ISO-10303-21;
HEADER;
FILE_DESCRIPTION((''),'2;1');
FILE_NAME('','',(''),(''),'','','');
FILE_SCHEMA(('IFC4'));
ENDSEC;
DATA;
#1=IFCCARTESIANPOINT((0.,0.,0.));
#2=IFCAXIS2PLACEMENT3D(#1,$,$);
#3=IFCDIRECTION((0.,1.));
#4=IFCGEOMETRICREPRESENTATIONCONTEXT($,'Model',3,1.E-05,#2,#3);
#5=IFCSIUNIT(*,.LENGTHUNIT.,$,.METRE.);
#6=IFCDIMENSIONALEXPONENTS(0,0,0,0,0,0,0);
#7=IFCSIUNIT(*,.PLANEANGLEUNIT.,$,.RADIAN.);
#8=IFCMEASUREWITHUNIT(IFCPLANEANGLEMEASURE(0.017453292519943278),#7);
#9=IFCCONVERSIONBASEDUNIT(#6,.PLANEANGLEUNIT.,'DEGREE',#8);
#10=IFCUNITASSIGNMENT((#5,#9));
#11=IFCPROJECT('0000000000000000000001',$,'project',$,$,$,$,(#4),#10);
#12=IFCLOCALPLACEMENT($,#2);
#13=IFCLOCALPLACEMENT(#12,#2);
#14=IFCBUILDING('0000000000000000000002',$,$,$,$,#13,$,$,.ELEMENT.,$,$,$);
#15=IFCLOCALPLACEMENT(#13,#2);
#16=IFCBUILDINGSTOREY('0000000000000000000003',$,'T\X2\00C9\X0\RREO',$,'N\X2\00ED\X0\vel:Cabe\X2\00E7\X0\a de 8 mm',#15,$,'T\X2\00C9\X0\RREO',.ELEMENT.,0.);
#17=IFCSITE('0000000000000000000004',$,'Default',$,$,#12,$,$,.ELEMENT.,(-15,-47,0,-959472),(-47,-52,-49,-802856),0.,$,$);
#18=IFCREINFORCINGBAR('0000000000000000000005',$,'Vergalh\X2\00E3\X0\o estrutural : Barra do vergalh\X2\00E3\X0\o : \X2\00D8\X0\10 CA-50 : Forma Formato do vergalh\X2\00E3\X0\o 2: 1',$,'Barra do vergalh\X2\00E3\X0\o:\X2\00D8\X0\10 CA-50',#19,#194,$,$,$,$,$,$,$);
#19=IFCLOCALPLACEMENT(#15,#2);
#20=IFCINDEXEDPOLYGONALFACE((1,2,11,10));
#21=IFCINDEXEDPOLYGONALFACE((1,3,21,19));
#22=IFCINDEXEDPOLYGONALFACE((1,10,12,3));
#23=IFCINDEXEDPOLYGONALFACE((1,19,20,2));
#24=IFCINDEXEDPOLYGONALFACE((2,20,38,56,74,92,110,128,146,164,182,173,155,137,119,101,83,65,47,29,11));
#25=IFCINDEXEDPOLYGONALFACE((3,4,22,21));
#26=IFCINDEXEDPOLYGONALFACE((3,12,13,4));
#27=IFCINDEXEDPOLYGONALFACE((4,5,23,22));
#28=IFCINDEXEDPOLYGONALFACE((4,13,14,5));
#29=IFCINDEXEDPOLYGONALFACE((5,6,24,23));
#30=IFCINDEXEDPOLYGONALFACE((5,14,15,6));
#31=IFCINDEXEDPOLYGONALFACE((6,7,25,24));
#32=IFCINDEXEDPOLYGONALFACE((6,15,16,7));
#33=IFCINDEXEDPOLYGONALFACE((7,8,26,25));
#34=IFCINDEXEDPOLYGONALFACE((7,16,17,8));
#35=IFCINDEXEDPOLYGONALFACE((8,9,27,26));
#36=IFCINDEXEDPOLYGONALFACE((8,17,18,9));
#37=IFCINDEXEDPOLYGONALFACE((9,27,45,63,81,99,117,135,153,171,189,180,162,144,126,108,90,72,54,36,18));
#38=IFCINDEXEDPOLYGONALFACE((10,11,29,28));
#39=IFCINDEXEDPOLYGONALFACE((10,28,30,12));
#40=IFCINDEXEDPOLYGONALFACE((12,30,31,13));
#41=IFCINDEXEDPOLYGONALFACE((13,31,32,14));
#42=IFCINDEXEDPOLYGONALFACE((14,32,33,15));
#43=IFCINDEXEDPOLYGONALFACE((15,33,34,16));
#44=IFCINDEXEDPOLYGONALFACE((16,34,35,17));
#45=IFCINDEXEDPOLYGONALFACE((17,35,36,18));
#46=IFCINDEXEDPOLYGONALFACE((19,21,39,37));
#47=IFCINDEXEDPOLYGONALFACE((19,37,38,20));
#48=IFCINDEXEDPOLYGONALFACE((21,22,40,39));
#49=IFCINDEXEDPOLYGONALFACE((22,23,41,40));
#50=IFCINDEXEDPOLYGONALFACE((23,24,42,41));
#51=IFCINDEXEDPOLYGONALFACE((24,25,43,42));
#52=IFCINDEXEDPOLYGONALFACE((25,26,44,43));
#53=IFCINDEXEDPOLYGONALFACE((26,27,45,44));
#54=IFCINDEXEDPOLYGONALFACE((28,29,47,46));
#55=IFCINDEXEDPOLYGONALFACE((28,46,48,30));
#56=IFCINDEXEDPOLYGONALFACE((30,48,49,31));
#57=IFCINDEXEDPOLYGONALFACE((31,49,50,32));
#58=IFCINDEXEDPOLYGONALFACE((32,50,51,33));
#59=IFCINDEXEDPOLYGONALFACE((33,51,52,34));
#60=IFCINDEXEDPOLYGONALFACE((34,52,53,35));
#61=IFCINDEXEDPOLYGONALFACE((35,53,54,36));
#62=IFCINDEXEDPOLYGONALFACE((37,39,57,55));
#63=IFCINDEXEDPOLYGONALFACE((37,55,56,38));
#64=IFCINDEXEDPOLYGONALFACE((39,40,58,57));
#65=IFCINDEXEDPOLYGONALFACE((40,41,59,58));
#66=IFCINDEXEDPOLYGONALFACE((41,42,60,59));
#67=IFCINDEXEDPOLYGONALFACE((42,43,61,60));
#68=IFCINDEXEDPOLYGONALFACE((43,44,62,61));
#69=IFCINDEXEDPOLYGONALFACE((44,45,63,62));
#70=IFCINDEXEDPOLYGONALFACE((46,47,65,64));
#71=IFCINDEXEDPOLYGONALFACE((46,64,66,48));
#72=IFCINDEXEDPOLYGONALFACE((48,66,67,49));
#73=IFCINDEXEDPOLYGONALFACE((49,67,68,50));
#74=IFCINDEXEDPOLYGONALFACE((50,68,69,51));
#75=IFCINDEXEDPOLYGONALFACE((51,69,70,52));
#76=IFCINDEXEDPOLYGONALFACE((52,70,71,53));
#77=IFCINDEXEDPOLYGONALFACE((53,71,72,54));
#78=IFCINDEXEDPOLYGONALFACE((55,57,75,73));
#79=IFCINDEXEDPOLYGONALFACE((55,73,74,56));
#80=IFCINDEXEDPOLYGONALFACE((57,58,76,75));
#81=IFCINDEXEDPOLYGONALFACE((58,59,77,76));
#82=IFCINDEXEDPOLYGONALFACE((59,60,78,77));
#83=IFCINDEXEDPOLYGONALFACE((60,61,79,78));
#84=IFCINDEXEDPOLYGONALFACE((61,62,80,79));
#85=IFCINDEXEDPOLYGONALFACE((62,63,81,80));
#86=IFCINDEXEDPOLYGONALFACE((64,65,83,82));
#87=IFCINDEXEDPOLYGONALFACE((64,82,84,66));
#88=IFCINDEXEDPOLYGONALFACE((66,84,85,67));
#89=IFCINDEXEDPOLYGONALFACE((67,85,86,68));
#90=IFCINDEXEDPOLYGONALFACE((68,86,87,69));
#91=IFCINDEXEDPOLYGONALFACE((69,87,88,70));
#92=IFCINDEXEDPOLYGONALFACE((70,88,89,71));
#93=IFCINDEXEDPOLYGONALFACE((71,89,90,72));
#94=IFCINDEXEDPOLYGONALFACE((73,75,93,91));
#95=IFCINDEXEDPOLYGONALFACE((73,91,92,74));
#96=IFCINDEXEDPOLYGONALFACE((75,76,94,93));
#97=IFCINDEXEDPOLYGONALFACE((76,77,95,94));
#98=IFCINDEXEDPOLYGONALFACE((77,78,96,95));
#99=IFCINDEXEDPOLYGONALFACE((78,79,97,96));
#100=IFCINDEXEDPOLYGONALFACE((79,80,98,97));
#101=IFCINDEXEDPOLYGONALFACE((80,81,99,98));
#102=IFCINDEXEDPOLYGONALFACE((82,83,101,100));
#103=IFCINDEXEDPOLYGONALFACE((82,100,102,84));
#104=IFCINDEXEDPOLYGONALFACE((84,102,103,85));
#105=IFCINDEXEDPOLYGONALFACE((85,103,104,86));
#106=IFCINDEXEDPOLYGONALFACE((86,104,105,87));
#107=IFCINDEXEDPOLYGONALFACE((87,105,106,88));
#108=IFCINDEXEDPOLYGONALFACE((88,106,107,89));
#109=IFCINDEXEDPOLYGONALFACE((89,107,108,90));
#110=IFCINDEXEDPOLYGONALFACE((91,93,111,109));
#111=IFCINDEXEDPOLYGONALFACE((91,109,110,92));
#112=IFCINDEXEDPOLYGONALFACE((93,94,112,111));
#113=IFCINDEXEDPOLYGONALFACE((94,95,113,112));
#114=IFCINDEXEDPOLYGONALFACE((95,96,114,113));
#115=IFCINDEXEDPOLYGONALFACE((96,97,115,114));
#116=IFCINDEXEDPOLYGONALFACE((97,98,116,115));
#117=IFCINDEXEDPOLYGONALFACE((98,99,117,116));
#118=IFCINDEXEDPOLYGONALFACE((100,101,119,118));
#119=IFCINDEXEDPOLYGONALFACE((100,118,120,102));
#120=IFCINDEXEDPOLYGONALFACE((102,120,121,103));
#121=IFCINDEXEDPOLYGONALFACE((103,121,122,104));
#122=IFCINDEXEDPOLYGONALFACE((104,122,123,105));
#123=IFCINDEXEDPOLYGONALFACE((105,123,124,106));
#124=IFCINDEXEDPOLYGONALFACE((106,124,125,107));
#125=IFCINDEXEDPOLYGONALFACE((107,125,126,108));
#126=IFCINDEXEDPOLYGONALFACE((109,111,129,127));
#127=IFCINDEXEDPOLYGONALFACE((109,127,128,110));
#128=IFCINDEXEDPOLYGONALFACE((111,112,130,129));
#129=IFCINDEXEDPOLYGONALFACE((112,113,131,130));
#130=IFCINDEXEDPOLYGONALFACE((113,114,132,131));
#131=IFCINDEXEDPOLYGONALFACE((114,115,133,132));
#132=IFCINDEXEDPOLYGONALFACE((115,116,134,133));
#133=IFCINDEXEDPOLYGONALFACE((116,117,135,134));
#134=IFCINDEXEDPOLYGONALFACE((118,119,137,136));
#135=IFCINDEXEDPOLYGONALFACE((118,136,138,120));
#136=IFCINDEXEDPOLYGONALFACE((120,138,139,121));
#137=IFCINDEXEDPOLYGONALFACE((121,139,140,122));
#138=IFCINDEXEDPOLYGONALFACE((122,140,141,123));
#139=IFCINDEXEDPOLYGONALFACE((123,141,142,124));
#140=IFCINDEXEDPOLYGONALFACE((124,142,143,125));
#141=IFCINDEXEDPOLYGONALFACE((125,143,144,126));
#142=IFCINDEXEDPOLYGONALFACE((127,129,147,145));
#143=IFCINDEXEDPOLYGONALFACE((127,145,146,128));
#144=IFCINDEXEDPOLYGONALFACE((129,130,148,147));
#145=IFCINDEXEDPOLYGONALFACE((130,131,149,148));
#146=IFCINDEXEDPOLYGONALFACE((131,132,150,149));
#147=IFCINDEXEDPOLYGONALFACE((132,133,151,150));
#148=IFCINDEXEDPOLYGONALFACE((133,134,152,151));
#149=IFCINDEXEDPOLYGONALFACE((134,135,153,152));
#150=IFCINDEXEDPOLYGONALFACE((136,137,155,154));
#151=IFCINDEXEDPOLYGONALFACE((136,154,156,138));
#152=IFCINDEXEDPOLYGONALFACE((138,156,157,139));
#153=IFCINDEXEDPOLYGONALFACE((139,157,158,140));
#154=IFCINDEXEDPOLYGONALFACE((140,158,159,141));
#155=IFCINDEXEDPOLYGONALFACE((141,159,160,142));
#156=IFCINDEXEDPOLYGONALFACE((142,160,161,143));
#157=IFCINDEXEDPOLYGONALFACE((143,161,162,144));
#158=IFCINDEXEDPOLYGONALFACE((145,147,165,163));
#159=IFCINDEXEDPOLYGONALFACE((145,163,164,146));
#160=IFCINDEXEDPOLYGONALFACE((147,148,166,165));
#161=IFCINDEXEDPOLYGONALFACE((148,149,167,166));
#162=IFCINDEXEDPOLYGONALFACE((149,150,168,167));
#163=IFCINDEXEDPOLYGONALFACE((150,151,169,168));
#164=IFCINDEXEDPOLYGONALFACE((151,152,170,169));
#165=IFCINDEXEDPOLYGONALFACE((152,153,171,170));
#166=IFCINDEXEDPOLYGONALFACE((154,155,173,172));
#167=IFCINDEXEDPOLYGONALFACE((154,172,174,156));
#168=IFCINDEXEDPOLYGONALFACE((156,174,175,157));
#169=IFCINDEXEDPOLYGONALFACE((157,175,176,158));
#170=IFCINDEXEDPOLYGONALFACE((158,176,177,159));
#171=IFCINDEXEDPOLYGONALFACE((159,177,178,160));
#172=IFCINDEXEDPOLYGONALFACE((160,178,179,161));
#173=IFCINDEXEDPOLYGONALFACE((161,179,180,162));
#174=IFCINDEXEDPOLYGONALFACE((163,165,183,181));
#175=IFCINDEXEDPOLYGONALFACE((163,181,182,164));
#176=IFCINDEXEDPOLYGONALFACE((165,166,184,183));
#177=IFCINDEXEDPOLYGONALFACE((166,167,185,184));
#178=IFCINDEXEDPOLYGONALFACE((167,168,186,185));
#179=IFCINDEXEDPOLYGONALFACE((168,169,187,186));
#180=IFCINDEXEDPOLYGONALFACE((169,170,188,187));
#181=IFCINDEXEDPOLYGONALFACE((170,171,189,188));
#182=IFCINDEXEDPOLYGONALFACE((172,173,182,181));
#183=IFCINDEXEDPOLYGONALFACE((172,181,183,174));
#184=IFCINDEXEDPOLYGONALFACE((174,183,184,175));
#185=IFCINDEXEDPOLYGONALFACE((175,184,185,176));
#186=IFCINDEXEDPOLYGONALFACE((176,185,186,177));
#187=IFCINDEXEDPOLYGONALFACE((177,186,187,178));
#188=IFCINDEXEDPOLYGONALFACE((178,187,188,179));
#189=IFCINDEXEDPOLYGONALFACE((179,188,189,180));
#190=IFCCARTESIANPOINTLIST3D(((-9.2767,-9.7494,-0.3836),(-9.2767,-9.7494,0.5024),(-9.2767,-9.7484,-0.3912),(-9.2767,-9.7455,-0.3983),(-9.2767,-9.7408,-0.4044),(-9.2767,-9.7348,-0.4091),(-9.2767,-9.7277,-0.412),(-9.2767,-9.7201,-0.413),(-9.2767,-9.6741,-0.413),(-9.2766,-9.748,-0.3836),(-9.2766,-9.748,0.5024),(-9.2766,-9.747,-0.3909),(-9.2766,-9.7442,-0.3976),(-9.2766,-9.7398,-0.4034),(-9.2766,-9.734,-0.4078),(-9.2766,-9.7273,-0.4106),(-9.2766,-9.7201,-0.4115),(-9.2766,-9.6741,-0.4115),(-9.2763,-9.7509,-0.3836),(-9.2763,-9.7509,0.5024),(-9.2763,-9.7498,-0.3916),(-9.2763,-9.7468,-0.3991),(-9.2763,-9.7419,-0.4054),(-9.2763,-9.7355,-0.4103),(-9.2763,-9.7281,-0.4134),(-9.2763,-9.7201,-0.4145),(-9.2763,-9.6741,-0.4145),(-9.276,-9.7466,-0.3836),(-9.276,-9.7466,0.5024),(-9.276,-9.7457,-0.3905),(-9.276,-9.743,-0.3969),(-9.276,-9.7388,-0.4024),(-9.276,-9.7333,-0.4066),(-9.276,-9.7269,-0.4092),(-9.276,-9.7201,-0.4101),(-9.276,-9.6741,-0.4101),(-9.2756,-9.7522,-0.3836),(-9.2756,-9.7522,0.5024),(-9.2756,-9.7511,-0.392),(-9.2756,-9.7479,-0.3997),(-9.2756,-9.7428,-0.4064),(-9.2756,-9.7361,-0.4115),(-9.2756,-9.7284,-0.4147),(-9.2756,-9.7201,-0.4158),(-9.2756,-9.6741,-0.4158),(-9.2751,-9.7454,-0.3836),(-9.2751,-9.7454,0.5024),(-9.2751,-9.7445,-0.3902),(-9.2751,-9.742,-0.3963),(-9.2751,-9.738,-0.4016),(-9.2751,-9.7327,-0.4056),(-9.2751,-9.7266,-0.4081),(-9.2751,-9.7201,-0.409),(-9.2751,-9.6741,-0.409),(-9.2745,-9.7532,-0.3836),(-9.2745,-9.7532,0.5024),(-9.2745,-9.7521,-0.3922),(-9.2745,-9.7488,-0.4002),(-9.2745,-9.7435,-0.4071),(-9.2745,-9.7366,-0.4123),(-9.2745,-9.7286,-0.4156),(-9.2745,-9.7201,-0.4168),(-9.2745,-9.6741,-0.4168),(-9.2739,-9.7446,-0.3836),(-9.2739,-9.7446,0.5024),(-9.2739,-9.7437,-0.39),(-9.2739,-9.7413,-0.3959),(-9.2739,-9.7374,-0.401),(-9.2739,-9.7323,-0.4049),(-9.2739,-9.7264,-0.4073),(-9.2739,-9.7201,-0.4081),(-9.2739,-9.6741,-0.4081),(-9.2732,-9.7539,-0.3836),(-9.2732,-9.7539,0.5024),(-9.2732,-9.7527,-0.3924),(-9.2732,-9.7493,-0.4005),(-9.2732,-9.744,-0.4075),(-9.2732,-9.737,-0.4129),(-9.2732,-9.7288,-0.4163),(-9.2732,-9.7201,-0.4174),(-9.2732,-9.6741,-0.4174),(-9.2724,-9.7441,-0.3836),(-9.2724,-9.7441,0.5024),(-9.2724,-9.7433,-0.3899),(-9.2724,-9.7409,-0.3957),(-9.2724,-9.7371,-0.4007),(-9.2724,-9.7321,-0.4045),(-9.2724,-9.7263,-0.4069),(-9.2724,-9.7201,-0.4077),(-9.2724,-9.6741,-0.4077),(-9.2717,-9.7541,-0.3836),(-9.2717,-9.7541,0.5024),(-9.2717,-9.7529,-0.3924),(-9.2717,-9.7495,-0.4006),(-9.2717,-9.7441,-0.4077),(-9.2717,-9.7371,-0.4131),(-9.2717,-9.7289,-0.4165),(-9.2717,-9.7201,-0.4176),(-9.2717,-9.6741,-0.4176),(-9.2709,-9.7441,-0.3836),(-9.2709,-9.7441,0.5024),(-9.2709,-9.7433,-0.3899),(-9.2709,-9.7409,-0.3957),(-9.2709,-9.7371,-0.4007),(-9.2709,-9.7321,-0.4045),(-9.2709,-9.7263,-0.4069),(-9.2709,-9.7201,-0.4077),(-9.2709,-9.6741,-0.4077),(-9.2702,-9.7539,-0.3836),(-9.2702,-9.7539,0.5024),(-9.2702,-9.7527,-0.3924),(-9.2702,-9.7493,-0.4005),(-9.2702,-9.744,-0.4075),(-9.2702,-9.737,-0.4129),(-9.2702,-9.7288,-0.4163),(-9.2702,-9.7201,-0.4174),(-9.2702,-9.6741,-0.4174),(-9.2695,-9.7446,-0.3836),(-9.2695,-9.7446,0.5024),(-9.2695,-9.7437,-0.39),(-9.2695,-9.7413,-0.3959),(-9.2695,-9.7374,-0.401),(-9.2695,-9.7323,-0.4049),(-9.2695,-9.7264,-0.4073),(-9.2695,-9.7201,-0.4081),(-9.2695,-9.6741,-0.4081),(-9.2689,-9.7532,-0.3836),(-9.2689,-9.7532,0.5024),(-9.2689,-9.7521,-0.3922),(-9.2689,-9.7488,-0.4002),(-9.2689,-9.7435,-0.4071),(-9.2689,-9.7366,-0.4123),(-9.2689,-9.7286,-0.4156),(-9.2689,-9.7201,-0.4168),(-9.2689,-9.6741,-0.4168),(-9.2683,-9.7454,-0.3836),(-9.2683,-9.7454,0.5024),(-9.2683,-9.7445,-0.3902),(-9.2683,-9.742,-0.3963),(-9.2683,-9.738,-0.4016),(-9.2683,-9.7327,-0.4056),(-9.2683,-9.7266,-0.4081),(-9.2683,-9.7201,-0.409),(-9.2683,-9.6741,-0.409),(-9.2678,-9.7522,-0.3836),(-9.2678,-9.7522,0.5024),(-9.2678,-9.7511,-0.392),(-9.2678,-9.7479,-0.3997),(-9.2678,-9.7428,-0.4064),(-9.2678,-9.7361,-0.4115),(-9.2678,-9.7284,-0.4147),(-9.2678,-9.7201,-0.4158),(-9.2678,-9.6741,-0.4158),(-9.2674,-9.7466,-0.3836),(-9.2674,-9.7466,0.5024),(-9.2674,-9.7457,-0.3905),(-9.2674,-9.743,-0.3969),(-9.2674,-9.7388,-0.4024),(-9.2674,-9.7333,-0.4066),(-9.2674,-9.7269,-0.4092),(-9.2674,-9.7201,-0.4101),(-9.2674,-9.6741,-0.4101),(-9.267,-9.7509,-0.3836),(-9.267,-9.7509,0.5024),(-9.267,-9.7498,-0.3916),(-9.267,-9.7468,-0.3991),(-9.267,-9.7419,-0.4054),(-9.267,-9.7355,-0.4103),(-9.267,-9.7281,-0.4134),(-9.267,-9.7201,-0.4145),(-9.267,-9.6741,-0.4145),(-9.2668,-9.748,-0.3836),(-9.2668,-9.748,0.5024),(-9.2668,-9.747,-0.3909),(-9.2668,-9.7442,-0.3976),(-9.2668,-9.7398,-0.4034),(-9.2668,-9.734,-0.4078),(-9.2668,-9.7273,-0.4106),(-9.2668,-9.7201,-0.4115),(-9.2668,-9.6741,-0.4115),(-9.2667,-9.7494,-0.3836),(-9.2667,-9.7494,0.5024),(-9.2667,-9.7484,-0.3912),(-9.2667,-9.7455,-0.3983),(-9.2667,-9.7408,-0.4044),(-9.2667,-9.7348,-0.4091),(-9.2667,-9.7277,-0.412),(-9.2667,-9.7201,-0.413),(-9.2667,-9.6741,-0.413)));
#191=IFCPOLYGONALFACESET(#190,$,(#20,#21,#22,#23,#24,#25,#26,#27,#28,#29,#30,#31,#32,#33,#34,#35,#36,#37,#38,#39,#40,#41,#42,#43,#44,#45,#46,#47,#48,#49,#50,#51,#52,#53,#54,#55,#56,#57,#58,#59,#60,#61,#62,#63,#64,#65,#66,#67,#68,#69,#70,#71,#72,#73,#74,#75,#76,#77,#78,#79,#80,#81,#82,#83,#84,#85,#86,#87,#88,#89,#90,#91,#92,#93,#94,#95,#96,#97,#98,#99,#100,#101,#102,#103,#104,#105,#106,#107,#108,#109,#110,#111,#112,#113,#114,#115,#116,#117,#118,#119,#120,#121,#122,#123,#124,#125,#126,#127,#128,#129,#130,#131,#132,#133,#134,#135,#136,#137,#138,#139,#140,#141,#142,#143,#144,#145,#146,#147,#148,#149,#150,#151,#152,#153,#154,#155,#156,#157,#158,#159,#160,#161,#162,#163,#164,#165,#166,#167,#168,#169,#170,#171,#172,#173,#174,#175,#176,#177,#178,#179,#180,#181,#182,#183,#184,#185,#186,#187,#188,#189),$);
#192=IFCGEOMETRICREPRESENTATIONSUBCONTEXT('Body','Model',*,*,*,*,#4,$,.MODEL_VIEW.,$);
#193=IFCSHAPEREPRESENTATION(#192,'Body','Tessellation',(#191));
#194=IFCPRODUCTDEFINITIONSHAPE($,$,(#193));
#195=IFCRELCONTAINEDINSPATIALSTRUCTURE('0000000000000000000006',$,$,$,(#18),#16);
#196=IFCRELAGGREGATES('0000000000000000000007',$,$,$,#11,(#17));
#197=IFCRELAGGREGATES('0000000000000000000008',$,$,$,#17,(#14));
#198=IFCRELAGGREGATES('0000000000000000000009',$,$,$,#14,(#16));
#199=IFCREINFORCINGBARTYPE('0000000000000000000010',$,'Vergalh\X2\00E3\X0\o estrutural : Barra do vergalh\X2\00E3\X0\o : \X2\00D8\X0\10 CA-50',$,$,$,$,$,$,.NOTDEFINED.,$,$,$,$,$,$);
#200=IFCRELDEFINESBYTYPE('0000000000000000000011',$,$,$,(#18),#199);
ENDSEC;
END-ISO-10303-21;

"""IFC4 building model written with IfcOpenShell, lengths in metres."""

from ifc_helpers import new_model, entity, si_unit, converted_unit, direction, origin, place, context, subcontext, project, spatial, type_object, element, save


model = new_model("IFC4")

# Units and contexts
model_context = context("Model", 3, precision=1e-05, world=origin(), true_north=direction((0.0, 1.0)))
body_context = subcontext(model_context, "Body", "Model", "MODEL_VIEW")
ifc_project = project(units=[si_unit("LENGTHUNIT", "METRE"), converted_unit("PLANEANGLEUNIT", "DEGREE", entity("IfcPlaneAngleMeasure", 0.017453292519943278), si_unit("PLANEANGLEUNIT", "RADIAN"), dimensions=[0, 0, 0, 0, 0, 0, 0])], contexts=[model_context])

# Site, building, storey
site_placement = place(None, origin())
site = spatial("IfcSite", under=ifc_project, at=site_placement, Name="Default", CompositionType="ELEMENT", RefLatitude=(-15, -47, 0, -959472), RefLongitude=(-47, -52, -49, -802856), RefElevation=0.0)
building_placement = place(site_placement, origin())
building = spatial("IfcBuilding", under=site, at=building_placement, CompositionType="ELEMENT")
storey_placement = place(building_placement, origin())
storey = spatial("IfcBuildingStorey", under=building, at=storey_placement, Name="TÉRREO", ObjectType="Nível:Cabeça de 8 mm", LongName="TÉRREO", CompositionType="ELEMENT", Elevation=0.0)

# Reinforcing bar
reinforcing_bar_type_1 = type_object("IfcReinforcingBarType", Name="Vergalhão estrutural : Barra do vergalhão : Ø10 CA-50", PredefinedType="NOTDEFINED")
reinforcing_bar_1_placement = place(storey_placement, origin())
element("IfcReinforcingBar", 1, at=reinforcing_bar_1_placement, inside=storey, type_object=reinforcing_bar_type_1, Name="Vergalhão estrutural : Barra do vergalhão : Ø10 CA-50 : Forma Formato do vergalhão 2: 1", ObjectType="Barra do vergalhão:Ø10 CA-50", context=body_context, shape_type="AdvancedSweptSolid", body=[
    entity("IfcSweptDiskSolid", entity("IfcIndexedPolyCurve", entity("IfcCartesianPointList3D", [[-9.2717, -9.6741, -0.4126], [-9.2717, -9.7201, -0.4126], [-9.2717, -9.7406, -0.4042], [-9.2717, -9.7491, -0.3836], [-9.2717, -9.7491, 0.5024]]), [entity("IfcLineIndex", [1, 2]), entity("IfcArcIndex", [2, 3, 4]), entity("IfcLineIndex", [4, 5])], False), 0.005, None, 0.0, 92.0),
])

save(model, "model.ifc")
